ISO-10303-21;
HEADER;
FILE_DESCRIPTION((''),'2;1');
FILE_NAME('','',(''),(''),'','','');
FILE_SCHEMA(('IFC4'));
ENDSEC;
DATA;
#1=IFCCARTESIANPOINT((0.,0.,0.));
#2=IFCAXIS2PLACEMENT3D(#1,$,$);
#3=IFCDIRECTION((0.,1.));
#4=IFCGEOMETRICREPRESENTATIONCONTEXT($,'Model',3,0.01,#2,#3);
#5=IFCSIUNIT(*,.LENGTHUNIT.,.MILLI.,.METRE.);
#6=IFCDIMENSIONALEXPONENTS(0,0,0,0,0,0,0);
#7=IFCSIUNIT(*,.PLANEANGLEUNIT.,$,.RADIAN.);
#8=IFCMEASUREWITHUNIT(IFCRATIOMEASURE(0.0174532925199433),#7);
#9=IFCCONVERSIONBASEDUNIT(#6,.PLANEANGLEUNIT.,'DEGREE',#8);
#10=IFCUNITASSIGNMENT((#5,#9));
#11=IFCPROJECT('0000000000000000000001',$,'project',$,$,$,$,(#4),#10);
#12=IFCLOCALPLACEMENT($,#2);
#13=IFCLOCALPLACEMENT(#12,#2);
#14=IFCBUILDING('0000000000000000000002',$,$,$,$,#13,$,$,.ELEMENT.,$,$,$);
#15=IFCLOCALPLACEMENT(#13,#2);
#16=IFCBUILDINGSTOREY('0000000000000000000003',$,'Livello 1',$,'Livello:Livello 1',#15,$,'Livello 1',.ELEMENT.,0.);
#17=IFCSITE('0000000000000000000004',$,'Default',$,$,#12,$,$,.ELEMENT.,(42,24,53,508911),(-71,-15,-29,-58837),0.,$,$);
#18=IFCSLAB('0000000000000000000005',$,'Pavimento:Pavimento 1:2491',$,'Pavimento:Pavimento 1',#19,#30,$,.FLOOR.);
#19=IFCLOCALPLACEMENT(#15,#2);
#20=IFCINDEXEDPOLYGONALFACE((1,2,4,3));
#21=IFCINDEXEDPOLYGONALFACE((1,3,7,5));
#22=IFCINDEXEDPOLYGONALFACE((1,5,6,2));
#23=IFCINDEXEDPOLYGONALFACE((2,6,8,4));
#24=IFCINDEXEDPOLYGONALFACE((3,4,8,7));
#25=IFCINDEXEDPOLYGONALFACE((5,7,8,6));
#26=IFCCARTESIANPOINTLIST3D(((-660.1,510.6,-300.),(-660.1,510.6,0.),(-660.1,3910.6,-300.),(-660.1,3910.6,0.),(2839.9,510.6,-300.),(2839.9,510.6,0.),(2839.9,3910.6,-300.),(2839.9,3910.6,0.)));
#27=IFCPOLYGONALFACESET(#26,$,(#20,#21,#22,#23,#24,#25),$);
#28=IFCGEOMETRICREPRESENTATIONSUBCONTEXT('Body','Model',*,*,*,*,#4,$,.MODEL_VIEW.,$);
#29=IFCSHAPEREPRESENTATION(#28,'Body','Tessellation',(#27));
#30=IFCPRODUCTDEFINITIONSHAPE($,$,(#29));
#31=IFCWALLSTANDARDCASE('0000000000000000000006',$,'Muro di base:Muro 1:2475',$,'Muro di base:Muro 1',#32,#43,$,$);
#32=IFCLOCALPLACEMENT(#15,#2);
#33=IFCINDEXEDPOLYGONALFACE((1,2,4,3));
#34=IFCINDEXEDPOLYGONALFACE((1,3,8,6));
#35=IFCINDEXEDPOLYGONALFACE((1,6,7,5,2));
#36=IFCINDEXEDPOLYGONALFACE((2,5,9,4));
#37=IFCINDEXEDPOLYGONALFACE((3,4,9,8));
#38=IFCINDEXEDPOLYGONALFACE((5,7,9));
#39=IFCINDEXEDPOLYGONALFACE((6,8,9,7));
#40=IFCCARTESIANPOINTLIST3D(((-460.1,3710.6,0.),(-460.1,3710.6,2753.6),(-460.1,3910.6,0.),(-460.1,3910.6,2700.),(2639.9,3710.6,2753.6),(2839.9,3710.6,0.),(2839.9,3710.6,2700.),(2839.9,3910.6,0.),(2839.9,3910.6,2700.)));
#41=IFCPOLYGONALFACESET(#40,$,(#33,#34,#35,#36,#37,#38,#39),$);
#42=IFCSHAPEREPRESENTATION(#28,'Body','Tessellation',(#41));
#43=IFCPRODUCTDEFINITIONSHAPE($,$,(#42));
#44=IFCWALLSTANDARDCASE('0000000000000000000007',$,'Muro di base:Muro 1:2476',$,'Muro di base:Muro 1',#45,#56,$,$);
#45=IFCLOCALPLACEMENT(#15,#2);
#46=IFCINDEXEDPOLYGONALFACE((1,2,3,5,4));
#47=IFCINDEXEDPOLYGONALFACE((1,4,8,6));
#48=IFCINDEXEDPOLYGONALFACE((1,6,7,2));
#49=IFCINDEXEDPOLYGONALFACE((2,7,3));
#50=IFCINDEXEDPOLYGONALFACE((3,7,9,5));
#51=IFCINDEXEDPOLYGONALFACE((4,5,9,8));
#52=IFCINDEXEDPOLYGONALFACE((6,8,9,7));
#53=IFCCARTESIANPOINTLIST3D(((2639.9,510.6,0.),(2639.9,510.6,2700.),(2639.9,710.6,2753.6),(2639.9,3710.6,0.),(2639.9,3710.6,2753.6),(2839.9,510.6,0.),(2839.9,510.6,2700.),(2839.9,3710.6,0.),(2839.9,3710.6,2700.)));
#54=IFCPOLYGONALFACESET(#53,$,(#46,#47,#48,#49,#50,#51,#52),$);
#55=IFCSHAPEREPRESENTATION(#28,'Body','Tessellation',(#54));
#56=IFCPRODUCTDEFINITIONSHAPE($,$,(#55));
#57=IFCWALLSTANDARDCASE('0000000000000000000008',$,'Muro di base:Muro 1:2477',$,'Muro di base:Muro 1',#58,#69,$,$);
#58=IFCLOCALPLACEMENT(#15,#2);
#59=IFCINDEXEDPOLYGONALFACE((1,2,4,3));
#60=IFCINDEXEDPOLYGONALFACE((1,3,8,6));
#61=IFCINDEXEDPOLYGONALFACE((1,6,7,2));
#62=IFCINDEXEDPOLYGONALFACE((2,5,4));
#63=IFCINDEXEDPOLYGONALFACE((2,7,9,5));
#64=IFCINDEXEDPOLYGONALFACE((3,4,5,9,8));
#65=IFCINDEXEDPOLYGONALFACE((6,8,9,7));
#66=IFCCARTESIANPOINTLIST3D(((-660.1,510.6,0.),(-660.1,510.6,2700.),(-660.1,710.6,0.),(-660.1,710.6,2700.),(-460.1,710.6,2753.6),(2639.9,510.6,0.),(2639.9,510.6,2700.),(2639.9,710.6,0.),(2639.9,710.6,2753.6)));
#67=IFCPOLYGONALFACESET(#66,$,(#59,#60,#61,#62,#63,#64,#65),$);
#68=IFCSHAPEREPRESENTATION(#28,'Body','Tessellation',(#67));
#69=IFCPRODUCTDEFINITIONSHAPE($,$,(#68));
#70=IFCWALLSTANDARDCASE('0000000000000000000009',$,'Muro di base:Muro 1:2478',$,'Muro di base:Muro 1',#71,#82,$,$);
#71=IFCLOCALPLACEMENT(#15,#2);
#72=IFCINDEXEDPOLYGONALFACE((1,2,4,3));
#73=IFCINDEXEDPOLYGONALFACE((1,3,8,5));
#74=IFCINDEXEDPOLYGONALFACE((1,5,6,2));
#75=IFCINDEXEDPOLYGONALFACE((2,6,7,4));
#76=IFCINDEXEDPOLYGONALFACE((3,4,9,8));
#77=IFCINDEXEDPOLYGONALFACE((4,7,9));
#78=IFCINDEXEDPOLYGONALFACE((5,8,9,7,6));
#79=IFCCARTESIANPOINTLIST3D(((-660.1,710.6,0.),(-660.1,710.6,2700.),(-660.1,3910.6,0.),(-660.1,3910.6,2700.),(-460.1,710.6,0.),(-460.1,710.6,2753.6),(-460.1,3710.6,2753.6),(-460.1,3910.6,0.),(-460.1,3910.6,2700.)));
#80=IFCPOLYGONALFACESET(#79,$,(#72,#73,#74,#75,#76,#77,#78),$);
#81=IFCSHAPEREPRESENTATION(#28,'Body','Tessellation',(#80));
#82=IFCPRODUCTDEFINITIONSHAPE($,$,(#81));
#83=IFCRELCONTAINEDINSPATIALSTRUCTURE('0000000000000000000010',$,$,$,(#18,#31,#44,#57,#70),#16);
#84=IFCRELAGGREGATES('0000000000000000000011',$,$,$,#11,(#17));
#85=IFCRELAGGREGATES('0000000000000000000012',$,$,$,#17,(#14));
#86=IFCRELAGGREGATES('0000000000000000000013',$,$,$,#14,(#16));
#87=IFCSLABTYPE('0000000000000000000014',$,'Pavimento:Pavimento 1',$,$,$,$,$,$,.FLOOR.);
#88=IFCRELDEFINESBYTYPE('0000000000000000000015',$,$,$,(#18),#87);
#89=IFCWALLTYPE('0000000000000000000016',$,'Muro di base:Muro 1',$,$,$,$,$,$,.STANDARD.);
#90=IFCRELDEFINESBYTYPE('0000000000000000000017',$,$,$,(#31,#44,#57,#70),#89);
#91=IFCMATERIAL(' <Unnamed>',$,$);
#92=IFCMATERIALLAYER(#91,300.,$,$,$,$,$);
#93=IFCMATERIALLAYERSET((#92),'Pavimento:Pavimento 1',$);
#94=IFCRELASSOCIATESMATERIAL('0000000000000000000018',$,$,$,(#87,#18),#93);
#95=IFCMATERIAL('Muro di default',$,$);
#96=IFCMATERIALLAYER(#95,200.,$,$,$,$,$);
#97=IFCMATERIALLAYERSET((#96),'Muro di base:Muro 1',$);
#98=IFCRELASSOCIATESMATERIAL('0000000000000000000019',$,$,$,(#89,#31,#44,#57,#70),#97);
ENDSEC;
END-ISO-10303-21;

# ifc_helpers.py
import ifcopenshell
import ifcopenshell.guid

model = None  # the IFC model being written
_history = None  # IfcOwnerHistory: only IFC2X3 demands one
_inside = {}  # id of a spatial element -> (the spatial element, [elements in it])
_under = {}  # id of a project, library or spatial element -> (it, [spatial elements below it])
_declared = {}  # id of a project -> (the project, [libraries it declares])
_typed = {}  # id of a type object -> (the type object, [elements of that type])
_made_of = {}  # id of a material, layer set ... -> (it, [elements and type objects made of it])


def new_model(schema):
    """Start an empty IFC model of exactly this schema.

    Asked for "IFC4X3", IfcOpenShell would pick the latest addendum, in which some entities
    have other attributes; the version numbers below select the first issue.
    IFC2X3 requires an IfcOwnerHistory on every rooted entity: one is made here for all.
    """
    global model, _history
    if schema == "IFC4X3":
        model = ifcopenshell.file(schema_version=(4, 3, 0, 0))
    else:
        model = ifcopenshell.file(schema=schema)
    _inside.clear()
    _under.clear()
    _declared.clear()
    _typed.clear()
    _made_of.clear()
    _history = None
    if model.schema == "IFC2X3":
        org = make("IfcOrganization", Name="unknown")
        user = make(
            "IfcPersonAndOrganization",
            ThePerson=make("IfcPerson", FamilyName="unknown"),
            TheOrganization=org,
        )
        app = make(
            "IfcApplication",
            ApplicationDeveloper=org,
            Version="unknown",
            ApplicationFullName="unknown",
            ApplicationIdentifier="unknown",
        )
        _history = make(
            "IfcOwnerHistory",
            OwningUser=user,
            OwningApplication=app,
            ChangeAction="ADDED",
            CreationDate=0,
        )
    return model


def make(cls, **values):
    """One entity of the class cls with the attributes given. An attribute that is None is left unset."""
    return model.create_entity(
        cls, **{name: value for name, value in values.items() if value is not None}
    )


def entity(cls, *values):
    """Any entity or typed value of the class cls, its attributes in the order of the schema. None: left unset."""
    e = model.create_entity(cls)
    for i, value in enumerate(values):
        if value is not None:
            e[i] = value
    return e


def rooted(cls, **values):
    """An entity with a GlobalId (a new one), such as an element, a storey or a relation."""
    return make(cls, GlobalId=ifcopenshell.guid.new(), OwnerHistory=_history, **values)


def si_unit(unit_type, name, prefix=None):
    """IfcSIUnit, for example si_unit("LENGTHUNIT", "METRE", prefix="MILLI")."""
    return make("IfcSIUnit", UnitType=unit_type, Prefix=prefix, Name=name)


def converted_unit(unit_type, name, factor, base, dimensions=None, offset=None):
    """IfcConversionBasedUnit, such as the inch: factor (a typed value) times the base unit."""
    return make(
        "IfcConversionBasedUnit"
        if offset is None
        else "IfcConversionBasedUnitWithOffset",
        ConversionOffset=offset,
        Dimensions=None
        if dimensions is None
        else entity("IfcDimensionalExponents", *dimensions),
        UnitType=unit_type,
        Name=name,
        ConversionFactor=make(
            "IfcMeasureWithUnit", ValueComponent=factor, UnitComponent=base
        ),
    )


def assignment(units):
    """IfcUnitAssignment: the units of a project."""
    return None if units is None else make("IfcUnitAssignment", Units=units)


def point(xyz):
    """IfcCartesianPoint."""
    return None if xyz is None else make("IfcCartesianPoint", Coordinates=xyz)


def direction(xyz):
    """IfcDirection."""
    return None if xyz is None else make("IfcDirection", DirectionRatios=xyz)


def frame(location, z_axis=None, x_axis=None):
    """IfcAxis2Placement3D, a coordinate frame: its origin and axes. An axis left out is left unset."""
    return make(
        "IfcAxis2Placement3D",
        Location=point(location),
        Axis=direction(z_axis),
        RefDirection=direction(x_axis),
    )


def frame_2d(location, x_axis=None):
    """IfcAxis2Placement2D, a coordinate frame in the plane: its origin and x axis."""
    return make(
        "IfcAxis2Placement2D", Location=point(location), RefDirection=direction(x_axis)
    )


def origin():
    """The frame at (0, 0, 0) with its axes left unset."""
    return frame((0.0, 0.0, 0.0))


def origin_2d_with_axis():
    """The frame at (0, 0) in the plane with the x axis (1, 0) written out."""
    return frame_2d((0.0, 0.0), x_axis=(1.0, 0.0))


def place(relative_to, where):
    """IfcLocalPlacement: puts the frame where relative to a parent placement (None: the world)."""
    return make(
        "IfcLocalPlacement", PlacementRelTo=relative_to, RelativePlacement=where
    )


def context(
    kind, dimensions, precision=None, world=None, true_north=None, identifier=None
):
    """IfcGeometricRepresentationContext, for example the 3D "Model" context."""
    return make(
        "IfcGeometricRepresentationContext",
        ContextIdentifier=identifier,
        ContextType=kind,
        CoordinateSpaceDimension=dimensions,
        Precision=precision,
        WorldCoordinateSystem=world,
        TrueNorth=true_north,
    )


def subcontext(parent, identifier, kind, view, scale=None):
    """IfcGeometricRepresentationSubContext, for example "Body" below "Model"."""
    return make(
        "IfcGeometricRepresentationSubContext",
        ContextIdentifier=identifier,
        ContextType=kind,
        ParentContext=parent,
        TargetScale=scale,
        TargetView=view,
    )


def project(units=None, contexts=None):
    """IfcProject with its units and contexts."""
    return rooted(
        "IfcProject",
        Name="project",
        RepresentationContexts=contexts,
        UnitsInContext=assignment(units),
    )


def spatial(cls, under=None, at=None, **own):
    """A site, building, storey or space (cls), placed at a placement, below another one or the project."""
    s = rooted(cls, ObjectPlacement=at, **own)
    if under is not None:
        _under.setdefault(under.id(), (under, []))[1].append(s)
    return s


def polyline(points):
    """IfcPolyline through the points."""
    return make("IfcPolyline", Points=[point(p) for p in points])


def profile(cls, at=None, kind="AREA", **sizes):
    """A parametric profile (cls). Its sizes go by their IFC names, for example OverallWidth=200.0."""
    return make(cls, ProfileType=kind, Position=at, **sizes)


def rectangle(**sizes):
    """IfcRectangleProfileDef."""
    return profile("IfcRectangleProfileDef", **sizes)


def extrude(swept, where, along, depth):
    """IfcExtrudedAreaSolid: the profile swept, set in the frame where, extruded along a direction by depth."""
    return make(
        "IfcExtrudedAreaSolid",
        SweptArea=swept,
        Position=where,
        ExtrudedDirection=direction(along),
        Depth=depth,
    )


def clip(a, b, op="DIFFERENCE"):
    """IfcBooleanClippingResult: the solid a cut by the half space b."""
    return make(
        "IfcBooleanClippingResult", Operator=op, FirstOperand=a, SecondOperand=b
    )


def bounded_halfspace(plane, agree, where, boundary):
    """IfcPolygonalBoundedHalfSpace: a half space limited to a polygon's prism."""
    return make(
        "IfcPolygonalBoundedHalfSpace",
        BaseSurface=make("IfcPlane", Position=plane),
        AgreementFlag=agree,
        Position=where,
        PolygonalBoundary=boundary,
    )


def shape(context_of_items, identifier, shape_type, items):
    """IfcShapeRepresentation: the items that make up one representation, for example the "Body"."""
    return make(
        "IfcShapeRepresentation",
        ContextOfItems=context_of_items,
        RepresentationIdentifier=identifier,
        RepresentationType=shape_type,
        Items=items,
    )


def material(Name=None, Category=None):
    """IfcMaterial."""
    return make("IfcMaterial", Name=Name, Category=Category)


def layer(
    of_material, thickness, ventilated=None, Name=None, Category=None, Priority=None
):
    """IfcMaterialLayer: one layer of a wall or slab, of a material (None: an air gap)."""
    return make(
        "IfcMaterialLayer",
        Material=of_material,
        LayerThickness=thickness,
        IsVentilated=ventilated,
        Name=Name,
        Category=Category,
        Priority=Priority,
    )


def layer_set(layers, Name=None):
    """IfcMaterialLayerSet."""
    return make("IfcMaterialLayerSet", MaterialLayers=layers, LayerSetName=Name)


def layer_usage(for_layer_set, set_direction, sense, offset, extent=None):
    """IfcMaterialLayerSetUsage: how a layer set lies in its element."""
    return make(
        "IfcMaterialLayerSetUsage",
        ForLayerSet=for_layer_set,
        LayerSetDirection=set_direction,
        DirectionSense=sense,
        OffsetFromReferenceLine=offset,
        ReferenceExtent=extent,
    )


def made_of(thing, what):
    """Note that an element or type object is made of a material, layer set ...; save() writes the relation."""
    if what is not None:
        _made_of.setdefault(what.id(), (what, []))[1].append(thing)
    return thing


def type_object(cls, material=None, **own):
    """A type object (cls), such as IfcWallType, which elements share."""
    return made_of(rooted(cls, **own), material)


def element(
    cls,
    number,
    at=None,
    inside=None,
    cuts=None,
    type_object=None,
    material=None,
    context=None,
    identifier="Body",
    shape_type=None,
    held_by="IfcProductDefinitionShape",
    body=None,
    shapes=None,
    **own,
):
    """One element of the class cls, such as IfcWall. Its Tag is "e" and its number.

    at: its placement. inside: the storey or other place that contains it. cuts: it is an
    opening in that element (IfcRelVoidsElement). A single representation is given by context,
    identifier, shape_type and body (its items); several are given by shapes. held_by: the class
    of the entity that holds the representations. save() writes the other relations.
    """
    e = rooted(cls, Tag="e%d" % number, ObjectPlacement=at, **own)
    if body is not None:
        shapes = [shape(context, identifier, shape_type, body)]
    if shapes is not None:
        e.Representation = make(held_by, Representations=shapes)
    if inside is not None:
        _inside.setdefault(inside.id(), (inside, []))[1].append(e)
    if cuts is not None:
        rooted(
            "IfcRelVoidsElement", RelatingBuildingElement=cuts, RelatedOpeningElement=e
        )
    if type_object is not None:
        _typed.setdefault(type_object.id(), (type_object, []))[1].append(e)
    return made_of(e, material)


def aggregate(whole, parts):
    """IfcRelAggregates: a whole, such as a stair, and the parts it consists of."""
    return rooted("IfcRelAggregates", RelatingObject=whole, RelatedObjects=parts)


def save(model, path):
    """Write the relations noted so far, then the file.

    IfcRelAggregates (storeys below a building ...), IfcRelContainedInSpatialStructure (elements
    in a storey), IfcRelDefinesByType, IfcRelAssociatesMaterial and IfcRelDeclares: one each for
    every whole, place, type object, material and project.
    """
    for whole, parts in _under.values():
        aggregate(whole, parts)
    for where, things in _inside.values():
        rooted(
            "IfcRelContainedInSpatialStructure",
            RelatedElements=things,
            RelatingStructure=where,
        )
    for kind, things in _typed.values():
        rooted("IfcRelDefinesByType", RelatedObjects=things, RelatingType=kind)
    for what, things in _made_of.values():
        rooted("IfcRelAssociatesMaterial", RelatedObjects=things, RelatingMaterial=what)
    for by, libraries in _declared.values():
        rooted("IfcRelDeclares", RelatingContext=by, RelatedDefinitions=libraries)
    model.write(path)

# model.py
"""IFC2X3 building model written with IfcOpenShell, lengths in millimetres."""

from ifc_helpers import new_model, entity, si_unit, converted_unit, direction, frame, frame_2d, origin, origin_2d_with_axis, place, context, subcontext, project, spatial, polyline, rectangle, extrude, clip, bounded_halfspace, material, layer, layer_set, layer_usage, type_object, element, save


model = new_model("IFC2X3")

# Units and contexts
model_context = context("Model", 3, precision=0.01, world=origin(), true_north=direction((0.0, 1.0)))
body_context = subcontext(model_context, "Body", "Model", "MODEL_VIEW")
ifc_project = project(units=[si_unit("LENGTHUNIT", "METRE", prefix="MILLI"), converted_unit("PLANEANGLEUNIT", "DEGREE", entity("IfcRatioMeasure", 0.0174532925199433), si_unit("PLANEANGLEUNIT", "RADIAN"), dimensions=[0, 0, 0, 0, 0, 0, 0])], contexts=[model_context])

# Site, building, storey
site_placement = place(None, origin())
site = spatial("IfcSite", under=ifc_project, at=site_placement, Name="Default", CompositionType="ELEMENT", RefLatitude=(42, 24, 53, 508911), RefLongitude=(-71, -15, -29, -58837), RefElevation=0.0)
building_placement = place(site_placement, origin())
building = spatial("IfcBuilding", under=site, at=building_placement, CompositionType="ELEMENT")
storey_placement = place(building_placement, origin())
storey = spatial("IfcBuildingStorey", under=building, at=storey_placement, Name="Livello 1", ObjectType="Livello:Livello 1", LongName="Livello 1", CompositionType="ELEMENT", Elevation=0.0)

# Slab
ifc_material_1 = material(Name=" <Unnamed>")
ifc_layer_1 = layer(ifc_material_1, 300.0)
ifc_layer_set_1 = layer_set([ifc_layer_1], Name="Pavimento:Pavimento 1")
ifc_layer_usage_1 = layer_usage(ifc_layer_set_1, "AXIS3", "POSITIVE", 0.0)
slab_type = type_object("IfcSlabType", Name="Pavimento:Pavimento 1", PredefinedType="FLOOR", material=ifc_layer_set_1)
slab_placement = place(storey_placement, origin())
element("IfcSlab", 1, at=slab_placement, inside=storey, type_object=slab_type, material=ifc_layer_usage_1, Name="Pavimento:Pavimento 1:2491", ObjectType="Pavimento:Pavimento 1", PredefinedType="FLOOR", context=body_context, shape_type="SweptSolid", body=[
    extrude(rectangle(XDim=3400.0, YDim=3500.0, at=origin_2d_with_axis()), frame((1089.9, 2210.6, 0.0), z_axis=(0.0, 0.0, -1.0), x_axis=(0.0, 1.0, 0.0)), (0.0, 0.0, 1.0), 300.0),
])

# Walls
ifc_material_2 = material(Name="Muro di default")
ifc_layer_2 = layer(ifc_material_2, 200.0)
ifc_layer_set_2 = layer_set([ifc_layer_2], Name="Muro di base:Muro 1")
ifc_layer_usage_2 = layer_usage(ifc_layer_set_2, "AXIS2", "NEGATIVE", 100.0)
wall_type = type_object("IfcWallType", Name="Muro di base:Muro 1", PredefinedType="STANDARD", material=ifc_layer_set_2)
wall_1_placement = place(storey_placement, frame((2839.9, 3810.6, 0.0), z_axis=(0.0, 0.0, 1.0), x_axis=(-1.0, 0.0, 0.0)))
element("IfcWallStandardCase", 2, at=wall_1_placement, inside=storey, type_object=wall_type, material=ifc_layer_usage_2, Name="Muro di base:Muro 1:2475", ObjectType="Muro di base:Muro 1", context=body_context, shape_type="Clipping", body=[
    clip(clip(extrude(rectangle(XDim=3300.0, YDim=200.0, at=frame_2d((1650.0, 0.0), x_axis=(-1.0, 0.0))), origin(), (0.0, 0.0, 1.0), 2753.6), bounded_halfspace(frame((0.0, -100.0, 2700.0), z_axis=(0.0, -0.258819, 0.965926), x_axis=(1.0, 0.0, 0.0)), False, frame((0.0, -100.0, 2700.0)), polyline([(0.0, 0.0), (3300.0, 0.0), (3300.0, 200.0), (200.0, 200.0), (0.0, 0.0)]))), bounded_halfspace(frame((200.0, 100.0, 2753.6), z_axis=(-0.258819, 0.0, 0.965926), x_axis=(0.0, -1.0, 0.0)), False, frame((200.0, 100.0, 2753.6)), polyline([(0.0, 0.0), (-200.0, 0.0), (-200.0, -200.0), (0.0, 0.0)]))),
])
ifc_layer_usage_3 = layer_usage(ifc_layer_set_2, "AXIS2", "NEGATIVE", 100.0)
wall_2_placement = place(storey_placement, frame((2739.9, 510.6, 0.0), z_axis=(0.0, 0.0, 1.0), x_axis=(0.0, 1.0, 0.0)))
element("IfcWallStandardCase", 3, at=wall_2_placement, inside=storey, type_object=wall_type, material=ifc_layer_usage_3, Name="Muro di base:Muro 1:2476", ObjectType="Muro di base:Muro 1", context=body_context, shape_type="Clipping", body=[
    clip(clip(extrude(rectangle(XDim=3200.0, YDim=200.0, at=frame_2d((1600.0, 0.0), x_axis=(-1.0, 0.0))), origin(), (0.0, 0.0, 1.0), 2753.6), bounded_halfspace(frame((0.0, -100.0, 2700.0), z_axis=(0.0, -0.258819, 0.965926), x_axis=(1.0, 0.0, 0.0)), False, frame((0.0, -100.0, 2700.0)), polyline([(0.0, 0.0), (3200.0, 0.0), (3200.0, 200.0), (200.0, 200.0), (0.0, 0.0)]))), bounded_halfspace(frame((200.0, 100.0, 2753.6), z_axis=(-0.258819, 0.0, 0.965926), x_axis=(0.0, -1.0, 0.0)), False, frame((200.0, 100.0, 2753.6)), polyline([(0.0, 0.0), (-200.0, 0.0), (-200.0, -200.0), (0.0, 0.0)]))),
])
ifc_layer_usage_4 = layer_usage(ifc_layer_set_2, "AXIS2", "NEGATIVE", 100.0)
wall_3_placement = place(storey_placement, frame((-660.1, 610.6, 0.0)))
element("IfcWallStandardCase", 4, at=wall_3_placement, inside=storey, type_object=wall_type, material=ifc_layer_usage_4, Name="Muro di base:Muro 1:2477", ObjectType="Muro di base:Muro 1", context=body_context, shape_type="Clipping", body=[
    clip(clip(extrude(rectangle(XDim=3300.0, YDim=200.0, at=frame_2d((1650.0, 0.0), x_axis=(-1.0, 0.0))), origin(), (0.0, 0.0, 1.0), 2753.6), bounded_halfspace(frame((0.0, -100.0, 2700.0), z_axis=(0.0, -0.258819, 0.965926), x_axis=(1.0, 0.0, 0.0)), False, frame((0.0, -100.0, 2700.0)), polyline([(0.0, 0.0), (3300.0, 0.0), (3300.0, 200.0), (200.0, 200.0), (0.0, 0.0)]))), bounded_halfspace(frame((200.0, 100.0, 2753.6), z_axis=(-0.258819, 0.0, 0.965926), x_axis=(0.0, -1.0, 0.0)), False, frame((200.0, 100.0, 2753.6)), polyline([(0.0, 0.0), (-200.0, 0.0), (-200.0, -200.0), (0.0, 0.0)]))),
])
ifc_layer_usage_5 = layer_usage(ifc_layer_set_2, "AXIS2", "NEGATIVE", 100.0)
wall_4_placement = place(storey_placement, frame((-560.1, 3910.6, 0.0), z_axis=(0.0, 0.0, 1.0), x_axis=(0.0, -1.0, 0.0)))
element("IfcWallStandardCase", 5, at=wall_4_placement, inside=storey, type_object=wall_type, material=ifc_layer_usage_5, Name="Muro di base:Muro 1:2478", ObjectType="Muro di base:Muro 1", context=body_context, shape_type="Clipping", body=[
    clip(clip(extrude(rectangle(XDim=3200.0, YDim=200.0, at=frame_2d((1600.0, 0.0), x_axis=(-1.0, 0.0))), origin(), (0.0, 0.0, 1.0), 2753.6), bounded_halfspace(frame((200.0, 100.0, 2753.6), z_axis=(-0.258819, 0.0, 0.965926), x_axis=(0.0, -1.0, 0.0)), False, frame((200.0, 100.0, 2753.6)), polyline([(0.0, 0.0), (-200.0, 0.0), (-200.0, -200.0), (0.0, 0.0)]))), bounded_halfspace(frame((0.0, -100.0, 2700.0), z_axis=(0.0, -0.258819, 0.965926), x_axis=(1.0, 0.0, 0.0)), False, frame((0.0, -100.0, 2700.0)), polyline([(0.0, 0.0), (3200.0, 0.0), (3200.0, 200.0), (200.0, 200.0), (0.0, 0.0)]))),
])

save(model, "model.ifc")
